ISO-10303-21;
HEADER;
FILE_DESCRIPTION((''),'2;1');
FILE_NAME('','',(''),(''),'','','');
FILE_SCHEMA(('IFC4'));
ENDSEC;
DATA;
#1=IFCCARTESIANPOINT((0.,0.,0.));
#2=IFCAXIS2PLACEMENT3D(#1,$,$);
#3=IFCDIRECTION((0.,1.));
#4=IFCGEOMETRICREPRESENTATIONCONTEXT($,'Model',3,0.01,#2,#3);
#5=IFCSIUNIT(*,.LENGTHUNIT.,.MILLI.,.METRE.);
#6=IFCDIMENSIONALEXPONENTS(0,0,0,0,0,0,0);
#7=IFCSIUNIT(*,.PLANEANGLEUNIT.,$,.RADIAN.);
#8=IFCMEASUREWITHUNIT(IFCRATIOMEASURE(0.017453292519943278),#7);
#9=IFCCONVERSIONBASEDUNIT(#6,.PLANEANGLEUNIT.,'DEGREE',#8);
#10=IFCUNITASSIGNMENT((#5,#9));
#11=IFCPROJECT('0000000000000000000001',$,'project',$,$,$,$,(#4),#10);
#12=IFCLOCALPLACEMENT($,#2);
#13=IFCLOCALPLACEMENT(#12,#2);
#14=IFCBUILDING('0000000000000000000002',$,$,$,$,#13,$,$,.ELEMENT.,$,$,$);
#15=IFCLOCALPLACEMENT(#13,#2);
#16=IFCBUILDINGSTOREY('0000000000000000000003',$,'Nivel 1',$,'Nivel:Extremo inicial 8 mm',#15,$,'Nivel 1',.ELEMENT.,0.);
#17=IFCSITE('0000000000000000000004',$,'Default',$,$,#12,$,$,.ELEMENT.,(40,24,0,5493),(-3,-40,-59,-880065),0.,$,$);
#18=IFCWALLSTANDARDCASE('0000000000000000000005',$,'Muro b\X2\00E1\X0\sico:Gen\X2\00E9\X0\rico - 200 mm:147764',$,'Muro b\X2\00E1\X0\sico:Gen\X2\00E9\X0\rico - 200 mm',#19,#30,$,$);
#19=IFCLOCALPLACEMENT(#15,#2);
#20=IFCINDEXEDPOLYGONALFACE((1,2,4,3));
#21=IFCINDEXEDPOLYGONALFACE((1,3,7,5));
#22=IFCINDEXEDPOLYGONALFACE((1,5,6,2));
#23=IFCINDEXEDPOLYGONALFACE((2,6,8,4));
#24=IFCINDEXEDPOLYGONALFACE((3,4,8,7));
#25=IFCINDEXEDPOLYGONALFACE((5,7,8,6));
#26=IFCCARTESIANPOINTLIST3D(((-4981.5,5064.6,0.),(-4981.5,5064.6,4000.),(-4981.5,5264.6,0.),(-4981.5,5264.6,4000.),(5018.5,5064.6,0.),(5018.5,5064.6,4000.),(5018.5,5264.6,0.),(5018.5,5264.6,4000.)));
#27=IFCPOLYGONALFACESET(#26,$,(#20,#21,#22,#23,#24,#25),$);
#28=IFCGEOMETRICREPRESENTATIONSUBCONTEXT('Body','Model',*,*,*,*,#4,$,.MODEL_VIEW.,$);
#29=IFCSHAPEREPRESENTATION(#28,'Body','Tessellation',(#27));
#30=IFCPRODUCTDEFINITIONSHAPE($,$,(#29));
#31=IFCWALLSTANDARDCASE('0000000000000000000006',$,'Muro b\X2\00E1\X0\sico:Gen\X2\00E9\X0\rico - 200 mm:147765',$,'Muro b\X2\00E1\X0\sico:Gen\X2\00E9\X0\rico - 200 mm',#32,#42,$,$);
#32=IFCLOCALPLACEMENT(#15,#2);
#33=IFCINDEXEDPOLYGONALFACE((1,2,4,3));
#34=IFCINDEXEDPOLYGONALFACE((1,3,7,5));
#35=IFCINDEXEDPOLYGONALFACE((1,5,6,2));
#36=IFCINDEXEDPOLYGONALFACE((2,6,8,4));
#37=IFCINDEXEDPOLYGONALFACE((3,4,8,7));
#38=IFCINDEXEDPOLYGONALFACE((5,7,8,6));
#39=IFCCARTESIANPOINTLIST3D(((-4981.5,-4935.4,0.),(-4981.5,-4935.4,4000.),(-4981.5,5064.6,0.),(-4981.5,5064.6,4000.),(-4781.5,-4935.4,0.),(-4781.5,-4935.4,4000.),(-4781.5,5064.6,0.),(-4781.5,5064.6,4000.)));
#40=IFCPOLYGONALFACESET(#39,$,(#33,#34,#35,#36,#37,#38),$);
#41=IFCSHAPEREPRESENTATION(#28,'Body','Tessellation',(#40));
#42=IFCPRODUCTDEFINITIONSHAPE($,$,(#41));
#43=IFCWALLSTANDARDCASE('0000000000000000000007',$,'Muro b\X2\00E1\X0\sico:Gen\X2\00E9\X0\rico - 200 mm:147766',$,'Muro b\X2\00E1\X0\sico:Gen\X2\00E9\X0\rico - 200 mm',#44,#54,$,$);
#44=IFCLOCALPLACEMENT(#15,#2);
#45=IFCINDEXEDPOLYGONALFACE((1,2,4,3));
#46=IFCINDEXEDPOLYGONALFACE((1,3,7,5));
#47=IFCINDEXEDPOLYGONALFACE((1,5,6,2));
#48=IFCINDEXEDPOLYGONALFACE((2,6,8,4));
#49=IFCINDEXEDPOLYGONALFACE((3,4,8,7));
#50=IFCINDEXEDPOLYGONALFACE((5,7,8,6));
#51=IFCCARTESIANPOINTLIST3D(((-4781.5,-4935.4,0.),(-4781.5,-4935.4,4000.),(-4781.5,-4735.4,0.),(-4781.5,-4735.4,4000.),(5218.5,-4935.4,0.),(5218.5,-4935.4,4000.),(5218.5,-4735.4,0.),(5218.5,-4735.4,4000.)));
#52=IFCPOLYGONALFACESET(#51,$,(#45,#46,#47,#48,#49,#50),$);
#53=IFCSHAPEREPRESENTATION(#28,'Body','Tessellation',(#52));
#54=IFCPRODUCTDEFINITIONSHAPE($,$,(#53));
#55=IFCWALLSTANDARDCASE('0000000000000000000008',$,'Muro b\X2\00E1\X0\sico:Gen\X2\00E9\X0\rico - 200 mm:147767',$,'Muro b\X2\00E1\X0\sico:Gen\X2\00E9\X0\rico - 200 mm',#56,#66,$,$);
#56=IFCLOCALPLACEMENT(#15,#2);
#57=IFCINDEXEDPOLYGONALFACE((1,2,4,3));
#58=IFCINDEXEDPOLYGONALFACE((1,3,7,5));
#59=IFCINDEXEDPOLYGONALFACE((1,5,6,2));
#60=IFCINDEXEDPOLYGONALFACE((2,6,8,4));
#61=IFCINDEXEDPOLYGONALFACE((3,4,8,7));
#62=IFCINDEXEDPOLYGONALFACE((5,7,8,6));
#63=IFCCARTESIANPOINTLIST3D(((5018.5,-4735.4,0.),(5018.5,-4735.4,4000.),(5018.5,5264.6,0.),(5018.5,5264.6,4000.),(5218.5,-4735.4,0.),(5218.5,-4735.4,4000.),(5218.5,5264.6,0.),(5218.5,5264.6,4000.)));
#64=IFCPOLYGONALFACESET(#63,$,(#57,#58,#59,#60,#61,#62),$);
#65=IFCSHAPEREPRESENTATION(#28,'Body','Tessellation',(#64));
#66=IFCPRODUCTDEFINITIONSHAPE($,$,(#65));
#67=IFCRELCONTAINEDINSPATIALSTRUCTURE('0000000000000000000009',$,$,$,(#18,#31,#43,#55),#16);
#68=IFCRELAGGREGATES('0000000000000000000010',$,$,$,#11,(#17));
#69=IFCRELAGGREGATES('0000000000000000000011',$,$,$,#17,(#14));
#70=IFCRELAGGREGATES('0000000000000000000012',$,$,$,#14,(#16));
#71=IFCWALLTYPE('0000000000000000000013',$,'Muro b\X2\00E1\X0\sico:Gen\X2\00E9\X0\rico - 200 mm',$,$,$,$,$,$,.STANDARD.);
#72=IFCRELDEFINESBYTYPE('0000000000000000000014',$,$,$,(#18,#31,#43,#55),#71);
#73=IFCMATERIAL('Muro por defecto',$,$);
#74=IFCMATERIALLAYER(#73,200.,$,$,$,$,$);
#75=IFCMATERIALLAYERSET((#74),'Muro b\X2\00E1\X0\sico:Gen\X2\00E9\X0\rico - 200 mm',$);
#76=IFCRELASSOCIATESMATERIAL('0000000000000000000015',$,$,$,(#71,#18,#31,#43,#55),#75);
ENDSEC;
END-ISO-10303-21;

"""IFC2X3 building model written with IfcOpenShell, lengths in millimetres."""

from ifc_helpers import new_model, entity, si_unit, converted_unit, direction, frame, frame_2d, origin, place, context, subcontext, project, spatial, rectangle, extrude, material, layer, layer_set, layer_usage, type_object, element, save


model = new_model("IFC2X3")

# Units and contexts
model_context = context("Model", 3, precision=0.01, world=origin(), true_north=direction((0.0, 1.0)))
body_context = subcontext(model_context, "Body", "Model", "MODEL_VIEW")
ifc_project = project(units=[si_unit("LENGTHUNIT", "METRE", prefix="MILLI"), converted_unit("PLANEANGLEUNIT", "DEGREE", entity("IfcRatioMeasure", 0.017453292519943278), si_unit("PLANEANGLEUNIT", "RADIAN"), dimensions=[0, 0, 0, 0, 0, 0, 0])], contexts=[model_context])

# Site, building, storey
site_placement = place(None, origin())
site = spatial("IfcSite", under=ifc_project, at=site_placement, Name="Default", CompositionType="ELEMENT", RefLatitude=(40, 24, 0, 5493), RefLongitude=(-3, -40, -59, -880065), RefElevation=0.0)
building_placement = place(site_placement, origin())
building = spatial("IfcBuilding", under=site, at=building_placement, CompositionType="ELEMENT")
storey_placement = place(building_placement, origin())
storey = spatial("IfcBuildingStorey", under=building, at=storey_placement, Name="Nivel 1", ObjectType="Nivel:Extremo inicial 8 mm", LongName="Nivel 1", CompositionType="ELEMENT", Elevation=0.0)

# Walls
ifc_material = material(Name="Muro por defecto")
ifc_layer = layer(ifc_material, 200.0)
ifc_layer_set = layer_set([ifc_layer], Name="Muro básico:Genérico - 200 mm")
ifc_layer_usage_1 = layer_usage(ifc_layer_set, "AXIS2", "NEGATIVE", 100.0)
wall_type = type_object("IfcWallType", Name="Muro básico:Genérico - 200 mm", PredefinedType="STANDARD", material=ifc_layer_set)
wall_1_placement = place(storey_placement, frame((-4981.5, 5164.6, 0.0)))
element("IfcWallStandardCase", 1, at=wall_1_placement, inside=storey, type_object=wall_type, material=ifc_layer_usage_1, Name="Muro básico:Genérico - 200 mm:147764", ObjectType="Muro básico:Genérico - 200 mm", context=body_context, shape_type="SweptSolid", body=[
    extrude(rectangle(XDim=10000.0, YDim=200.0, at=frame_2d((5000.0, 0.0), x_axis=(-1.0, 0.0))), origin(), (0.0, 0.0, 1.0), 4000.0),
])
ifc_layer_usage_2 = layer_usage(ifc_layer_set, "AXIS2", "NEGATIVE", 100.0)
wall_2_placement = place(storey_placement, frame((-4881.5, -4935.4, 0.0), z_axis=(0.0, 0.0, 1.0), x_axis=(0.0, 1.0, 0.0)))
element("IfcWallStandardCase", 2, at=wall_2_placement, inside=storey, type_object=wall_type, material=ifc_layer_usage_2, Name="Muro básico:Genérico - 200 mm:147765", ObjectType="Muro básico:Genérico - 200 mm", context=body_context, shape_type="SweptSolid", body=[
    extrude(rectangle(XDim=10000.0, YDim=200.0, at=frame_2d((5000.0, 0.0), x_axis=(-1.0, 0.0))), origin(), (0.0, 0.0, 1.0), 4000.0),
])
ifc_layer_usage_3 = layer_usage(ifc_layer_set, "AXIS2", "NEGATIVE", 100.0)
wall_3_placement = place(storey_placement, frame((5218.5, -4835.4, 0.0), z_axis=(0.0, 0.0, 1.0), x_axis=(-1.0, 0.0, 0.0)))
element("IfcWallStandardCase", 3, at=wall_3_placement, inside=storey, type_object=wall_type, material=ifc_layer_usage_3, Name="Muro básico:Genérico - 200 mm:147766", ObjectType="Muro básico:Genérico - 200 mm", context=body_context, shape_type="SweptSolid", body=[
    extrude(rectangle(XDim=10000.0, YDim=200.0, at=frame_2d((5000.0, 0.0), x_axis=(-1.0, 0.0))), origin(), (0.0, 0.0, 1.0), 4000.0),
])
ifc_layer_usage_4 = layer_usage(ifc_layer_set, "AXIS2", "NEGATIVE", 100.0)
wall_4_placement = place(storey_placement, frame((5118.5, 5264.6, 0.0), z_axis=(0.0, 0.0, 1.0), x_axis=(0.0, -1.0, 0.0)))
element("IfcWallStandardCase", 4, at=wall_4_placement, inside=storey, type_object=wall_type, material=ifc_layer_usage_4, Name="Muro básico:Genérico - 200 mm:147767", ObjectType="Muro básico:Genérico - 200 mm", context=body_context, shape_type="SweptSolid", body=[
    extrude(rectangle(XDim=10000.0, YDim=200.0, at=frame_2d((5000.0, 0.0), x_axis=(-1.0, 0.0))), origin(), (0.0, 0.0, 1.0), 4000.0),
])

save(model, "model.ifc")
